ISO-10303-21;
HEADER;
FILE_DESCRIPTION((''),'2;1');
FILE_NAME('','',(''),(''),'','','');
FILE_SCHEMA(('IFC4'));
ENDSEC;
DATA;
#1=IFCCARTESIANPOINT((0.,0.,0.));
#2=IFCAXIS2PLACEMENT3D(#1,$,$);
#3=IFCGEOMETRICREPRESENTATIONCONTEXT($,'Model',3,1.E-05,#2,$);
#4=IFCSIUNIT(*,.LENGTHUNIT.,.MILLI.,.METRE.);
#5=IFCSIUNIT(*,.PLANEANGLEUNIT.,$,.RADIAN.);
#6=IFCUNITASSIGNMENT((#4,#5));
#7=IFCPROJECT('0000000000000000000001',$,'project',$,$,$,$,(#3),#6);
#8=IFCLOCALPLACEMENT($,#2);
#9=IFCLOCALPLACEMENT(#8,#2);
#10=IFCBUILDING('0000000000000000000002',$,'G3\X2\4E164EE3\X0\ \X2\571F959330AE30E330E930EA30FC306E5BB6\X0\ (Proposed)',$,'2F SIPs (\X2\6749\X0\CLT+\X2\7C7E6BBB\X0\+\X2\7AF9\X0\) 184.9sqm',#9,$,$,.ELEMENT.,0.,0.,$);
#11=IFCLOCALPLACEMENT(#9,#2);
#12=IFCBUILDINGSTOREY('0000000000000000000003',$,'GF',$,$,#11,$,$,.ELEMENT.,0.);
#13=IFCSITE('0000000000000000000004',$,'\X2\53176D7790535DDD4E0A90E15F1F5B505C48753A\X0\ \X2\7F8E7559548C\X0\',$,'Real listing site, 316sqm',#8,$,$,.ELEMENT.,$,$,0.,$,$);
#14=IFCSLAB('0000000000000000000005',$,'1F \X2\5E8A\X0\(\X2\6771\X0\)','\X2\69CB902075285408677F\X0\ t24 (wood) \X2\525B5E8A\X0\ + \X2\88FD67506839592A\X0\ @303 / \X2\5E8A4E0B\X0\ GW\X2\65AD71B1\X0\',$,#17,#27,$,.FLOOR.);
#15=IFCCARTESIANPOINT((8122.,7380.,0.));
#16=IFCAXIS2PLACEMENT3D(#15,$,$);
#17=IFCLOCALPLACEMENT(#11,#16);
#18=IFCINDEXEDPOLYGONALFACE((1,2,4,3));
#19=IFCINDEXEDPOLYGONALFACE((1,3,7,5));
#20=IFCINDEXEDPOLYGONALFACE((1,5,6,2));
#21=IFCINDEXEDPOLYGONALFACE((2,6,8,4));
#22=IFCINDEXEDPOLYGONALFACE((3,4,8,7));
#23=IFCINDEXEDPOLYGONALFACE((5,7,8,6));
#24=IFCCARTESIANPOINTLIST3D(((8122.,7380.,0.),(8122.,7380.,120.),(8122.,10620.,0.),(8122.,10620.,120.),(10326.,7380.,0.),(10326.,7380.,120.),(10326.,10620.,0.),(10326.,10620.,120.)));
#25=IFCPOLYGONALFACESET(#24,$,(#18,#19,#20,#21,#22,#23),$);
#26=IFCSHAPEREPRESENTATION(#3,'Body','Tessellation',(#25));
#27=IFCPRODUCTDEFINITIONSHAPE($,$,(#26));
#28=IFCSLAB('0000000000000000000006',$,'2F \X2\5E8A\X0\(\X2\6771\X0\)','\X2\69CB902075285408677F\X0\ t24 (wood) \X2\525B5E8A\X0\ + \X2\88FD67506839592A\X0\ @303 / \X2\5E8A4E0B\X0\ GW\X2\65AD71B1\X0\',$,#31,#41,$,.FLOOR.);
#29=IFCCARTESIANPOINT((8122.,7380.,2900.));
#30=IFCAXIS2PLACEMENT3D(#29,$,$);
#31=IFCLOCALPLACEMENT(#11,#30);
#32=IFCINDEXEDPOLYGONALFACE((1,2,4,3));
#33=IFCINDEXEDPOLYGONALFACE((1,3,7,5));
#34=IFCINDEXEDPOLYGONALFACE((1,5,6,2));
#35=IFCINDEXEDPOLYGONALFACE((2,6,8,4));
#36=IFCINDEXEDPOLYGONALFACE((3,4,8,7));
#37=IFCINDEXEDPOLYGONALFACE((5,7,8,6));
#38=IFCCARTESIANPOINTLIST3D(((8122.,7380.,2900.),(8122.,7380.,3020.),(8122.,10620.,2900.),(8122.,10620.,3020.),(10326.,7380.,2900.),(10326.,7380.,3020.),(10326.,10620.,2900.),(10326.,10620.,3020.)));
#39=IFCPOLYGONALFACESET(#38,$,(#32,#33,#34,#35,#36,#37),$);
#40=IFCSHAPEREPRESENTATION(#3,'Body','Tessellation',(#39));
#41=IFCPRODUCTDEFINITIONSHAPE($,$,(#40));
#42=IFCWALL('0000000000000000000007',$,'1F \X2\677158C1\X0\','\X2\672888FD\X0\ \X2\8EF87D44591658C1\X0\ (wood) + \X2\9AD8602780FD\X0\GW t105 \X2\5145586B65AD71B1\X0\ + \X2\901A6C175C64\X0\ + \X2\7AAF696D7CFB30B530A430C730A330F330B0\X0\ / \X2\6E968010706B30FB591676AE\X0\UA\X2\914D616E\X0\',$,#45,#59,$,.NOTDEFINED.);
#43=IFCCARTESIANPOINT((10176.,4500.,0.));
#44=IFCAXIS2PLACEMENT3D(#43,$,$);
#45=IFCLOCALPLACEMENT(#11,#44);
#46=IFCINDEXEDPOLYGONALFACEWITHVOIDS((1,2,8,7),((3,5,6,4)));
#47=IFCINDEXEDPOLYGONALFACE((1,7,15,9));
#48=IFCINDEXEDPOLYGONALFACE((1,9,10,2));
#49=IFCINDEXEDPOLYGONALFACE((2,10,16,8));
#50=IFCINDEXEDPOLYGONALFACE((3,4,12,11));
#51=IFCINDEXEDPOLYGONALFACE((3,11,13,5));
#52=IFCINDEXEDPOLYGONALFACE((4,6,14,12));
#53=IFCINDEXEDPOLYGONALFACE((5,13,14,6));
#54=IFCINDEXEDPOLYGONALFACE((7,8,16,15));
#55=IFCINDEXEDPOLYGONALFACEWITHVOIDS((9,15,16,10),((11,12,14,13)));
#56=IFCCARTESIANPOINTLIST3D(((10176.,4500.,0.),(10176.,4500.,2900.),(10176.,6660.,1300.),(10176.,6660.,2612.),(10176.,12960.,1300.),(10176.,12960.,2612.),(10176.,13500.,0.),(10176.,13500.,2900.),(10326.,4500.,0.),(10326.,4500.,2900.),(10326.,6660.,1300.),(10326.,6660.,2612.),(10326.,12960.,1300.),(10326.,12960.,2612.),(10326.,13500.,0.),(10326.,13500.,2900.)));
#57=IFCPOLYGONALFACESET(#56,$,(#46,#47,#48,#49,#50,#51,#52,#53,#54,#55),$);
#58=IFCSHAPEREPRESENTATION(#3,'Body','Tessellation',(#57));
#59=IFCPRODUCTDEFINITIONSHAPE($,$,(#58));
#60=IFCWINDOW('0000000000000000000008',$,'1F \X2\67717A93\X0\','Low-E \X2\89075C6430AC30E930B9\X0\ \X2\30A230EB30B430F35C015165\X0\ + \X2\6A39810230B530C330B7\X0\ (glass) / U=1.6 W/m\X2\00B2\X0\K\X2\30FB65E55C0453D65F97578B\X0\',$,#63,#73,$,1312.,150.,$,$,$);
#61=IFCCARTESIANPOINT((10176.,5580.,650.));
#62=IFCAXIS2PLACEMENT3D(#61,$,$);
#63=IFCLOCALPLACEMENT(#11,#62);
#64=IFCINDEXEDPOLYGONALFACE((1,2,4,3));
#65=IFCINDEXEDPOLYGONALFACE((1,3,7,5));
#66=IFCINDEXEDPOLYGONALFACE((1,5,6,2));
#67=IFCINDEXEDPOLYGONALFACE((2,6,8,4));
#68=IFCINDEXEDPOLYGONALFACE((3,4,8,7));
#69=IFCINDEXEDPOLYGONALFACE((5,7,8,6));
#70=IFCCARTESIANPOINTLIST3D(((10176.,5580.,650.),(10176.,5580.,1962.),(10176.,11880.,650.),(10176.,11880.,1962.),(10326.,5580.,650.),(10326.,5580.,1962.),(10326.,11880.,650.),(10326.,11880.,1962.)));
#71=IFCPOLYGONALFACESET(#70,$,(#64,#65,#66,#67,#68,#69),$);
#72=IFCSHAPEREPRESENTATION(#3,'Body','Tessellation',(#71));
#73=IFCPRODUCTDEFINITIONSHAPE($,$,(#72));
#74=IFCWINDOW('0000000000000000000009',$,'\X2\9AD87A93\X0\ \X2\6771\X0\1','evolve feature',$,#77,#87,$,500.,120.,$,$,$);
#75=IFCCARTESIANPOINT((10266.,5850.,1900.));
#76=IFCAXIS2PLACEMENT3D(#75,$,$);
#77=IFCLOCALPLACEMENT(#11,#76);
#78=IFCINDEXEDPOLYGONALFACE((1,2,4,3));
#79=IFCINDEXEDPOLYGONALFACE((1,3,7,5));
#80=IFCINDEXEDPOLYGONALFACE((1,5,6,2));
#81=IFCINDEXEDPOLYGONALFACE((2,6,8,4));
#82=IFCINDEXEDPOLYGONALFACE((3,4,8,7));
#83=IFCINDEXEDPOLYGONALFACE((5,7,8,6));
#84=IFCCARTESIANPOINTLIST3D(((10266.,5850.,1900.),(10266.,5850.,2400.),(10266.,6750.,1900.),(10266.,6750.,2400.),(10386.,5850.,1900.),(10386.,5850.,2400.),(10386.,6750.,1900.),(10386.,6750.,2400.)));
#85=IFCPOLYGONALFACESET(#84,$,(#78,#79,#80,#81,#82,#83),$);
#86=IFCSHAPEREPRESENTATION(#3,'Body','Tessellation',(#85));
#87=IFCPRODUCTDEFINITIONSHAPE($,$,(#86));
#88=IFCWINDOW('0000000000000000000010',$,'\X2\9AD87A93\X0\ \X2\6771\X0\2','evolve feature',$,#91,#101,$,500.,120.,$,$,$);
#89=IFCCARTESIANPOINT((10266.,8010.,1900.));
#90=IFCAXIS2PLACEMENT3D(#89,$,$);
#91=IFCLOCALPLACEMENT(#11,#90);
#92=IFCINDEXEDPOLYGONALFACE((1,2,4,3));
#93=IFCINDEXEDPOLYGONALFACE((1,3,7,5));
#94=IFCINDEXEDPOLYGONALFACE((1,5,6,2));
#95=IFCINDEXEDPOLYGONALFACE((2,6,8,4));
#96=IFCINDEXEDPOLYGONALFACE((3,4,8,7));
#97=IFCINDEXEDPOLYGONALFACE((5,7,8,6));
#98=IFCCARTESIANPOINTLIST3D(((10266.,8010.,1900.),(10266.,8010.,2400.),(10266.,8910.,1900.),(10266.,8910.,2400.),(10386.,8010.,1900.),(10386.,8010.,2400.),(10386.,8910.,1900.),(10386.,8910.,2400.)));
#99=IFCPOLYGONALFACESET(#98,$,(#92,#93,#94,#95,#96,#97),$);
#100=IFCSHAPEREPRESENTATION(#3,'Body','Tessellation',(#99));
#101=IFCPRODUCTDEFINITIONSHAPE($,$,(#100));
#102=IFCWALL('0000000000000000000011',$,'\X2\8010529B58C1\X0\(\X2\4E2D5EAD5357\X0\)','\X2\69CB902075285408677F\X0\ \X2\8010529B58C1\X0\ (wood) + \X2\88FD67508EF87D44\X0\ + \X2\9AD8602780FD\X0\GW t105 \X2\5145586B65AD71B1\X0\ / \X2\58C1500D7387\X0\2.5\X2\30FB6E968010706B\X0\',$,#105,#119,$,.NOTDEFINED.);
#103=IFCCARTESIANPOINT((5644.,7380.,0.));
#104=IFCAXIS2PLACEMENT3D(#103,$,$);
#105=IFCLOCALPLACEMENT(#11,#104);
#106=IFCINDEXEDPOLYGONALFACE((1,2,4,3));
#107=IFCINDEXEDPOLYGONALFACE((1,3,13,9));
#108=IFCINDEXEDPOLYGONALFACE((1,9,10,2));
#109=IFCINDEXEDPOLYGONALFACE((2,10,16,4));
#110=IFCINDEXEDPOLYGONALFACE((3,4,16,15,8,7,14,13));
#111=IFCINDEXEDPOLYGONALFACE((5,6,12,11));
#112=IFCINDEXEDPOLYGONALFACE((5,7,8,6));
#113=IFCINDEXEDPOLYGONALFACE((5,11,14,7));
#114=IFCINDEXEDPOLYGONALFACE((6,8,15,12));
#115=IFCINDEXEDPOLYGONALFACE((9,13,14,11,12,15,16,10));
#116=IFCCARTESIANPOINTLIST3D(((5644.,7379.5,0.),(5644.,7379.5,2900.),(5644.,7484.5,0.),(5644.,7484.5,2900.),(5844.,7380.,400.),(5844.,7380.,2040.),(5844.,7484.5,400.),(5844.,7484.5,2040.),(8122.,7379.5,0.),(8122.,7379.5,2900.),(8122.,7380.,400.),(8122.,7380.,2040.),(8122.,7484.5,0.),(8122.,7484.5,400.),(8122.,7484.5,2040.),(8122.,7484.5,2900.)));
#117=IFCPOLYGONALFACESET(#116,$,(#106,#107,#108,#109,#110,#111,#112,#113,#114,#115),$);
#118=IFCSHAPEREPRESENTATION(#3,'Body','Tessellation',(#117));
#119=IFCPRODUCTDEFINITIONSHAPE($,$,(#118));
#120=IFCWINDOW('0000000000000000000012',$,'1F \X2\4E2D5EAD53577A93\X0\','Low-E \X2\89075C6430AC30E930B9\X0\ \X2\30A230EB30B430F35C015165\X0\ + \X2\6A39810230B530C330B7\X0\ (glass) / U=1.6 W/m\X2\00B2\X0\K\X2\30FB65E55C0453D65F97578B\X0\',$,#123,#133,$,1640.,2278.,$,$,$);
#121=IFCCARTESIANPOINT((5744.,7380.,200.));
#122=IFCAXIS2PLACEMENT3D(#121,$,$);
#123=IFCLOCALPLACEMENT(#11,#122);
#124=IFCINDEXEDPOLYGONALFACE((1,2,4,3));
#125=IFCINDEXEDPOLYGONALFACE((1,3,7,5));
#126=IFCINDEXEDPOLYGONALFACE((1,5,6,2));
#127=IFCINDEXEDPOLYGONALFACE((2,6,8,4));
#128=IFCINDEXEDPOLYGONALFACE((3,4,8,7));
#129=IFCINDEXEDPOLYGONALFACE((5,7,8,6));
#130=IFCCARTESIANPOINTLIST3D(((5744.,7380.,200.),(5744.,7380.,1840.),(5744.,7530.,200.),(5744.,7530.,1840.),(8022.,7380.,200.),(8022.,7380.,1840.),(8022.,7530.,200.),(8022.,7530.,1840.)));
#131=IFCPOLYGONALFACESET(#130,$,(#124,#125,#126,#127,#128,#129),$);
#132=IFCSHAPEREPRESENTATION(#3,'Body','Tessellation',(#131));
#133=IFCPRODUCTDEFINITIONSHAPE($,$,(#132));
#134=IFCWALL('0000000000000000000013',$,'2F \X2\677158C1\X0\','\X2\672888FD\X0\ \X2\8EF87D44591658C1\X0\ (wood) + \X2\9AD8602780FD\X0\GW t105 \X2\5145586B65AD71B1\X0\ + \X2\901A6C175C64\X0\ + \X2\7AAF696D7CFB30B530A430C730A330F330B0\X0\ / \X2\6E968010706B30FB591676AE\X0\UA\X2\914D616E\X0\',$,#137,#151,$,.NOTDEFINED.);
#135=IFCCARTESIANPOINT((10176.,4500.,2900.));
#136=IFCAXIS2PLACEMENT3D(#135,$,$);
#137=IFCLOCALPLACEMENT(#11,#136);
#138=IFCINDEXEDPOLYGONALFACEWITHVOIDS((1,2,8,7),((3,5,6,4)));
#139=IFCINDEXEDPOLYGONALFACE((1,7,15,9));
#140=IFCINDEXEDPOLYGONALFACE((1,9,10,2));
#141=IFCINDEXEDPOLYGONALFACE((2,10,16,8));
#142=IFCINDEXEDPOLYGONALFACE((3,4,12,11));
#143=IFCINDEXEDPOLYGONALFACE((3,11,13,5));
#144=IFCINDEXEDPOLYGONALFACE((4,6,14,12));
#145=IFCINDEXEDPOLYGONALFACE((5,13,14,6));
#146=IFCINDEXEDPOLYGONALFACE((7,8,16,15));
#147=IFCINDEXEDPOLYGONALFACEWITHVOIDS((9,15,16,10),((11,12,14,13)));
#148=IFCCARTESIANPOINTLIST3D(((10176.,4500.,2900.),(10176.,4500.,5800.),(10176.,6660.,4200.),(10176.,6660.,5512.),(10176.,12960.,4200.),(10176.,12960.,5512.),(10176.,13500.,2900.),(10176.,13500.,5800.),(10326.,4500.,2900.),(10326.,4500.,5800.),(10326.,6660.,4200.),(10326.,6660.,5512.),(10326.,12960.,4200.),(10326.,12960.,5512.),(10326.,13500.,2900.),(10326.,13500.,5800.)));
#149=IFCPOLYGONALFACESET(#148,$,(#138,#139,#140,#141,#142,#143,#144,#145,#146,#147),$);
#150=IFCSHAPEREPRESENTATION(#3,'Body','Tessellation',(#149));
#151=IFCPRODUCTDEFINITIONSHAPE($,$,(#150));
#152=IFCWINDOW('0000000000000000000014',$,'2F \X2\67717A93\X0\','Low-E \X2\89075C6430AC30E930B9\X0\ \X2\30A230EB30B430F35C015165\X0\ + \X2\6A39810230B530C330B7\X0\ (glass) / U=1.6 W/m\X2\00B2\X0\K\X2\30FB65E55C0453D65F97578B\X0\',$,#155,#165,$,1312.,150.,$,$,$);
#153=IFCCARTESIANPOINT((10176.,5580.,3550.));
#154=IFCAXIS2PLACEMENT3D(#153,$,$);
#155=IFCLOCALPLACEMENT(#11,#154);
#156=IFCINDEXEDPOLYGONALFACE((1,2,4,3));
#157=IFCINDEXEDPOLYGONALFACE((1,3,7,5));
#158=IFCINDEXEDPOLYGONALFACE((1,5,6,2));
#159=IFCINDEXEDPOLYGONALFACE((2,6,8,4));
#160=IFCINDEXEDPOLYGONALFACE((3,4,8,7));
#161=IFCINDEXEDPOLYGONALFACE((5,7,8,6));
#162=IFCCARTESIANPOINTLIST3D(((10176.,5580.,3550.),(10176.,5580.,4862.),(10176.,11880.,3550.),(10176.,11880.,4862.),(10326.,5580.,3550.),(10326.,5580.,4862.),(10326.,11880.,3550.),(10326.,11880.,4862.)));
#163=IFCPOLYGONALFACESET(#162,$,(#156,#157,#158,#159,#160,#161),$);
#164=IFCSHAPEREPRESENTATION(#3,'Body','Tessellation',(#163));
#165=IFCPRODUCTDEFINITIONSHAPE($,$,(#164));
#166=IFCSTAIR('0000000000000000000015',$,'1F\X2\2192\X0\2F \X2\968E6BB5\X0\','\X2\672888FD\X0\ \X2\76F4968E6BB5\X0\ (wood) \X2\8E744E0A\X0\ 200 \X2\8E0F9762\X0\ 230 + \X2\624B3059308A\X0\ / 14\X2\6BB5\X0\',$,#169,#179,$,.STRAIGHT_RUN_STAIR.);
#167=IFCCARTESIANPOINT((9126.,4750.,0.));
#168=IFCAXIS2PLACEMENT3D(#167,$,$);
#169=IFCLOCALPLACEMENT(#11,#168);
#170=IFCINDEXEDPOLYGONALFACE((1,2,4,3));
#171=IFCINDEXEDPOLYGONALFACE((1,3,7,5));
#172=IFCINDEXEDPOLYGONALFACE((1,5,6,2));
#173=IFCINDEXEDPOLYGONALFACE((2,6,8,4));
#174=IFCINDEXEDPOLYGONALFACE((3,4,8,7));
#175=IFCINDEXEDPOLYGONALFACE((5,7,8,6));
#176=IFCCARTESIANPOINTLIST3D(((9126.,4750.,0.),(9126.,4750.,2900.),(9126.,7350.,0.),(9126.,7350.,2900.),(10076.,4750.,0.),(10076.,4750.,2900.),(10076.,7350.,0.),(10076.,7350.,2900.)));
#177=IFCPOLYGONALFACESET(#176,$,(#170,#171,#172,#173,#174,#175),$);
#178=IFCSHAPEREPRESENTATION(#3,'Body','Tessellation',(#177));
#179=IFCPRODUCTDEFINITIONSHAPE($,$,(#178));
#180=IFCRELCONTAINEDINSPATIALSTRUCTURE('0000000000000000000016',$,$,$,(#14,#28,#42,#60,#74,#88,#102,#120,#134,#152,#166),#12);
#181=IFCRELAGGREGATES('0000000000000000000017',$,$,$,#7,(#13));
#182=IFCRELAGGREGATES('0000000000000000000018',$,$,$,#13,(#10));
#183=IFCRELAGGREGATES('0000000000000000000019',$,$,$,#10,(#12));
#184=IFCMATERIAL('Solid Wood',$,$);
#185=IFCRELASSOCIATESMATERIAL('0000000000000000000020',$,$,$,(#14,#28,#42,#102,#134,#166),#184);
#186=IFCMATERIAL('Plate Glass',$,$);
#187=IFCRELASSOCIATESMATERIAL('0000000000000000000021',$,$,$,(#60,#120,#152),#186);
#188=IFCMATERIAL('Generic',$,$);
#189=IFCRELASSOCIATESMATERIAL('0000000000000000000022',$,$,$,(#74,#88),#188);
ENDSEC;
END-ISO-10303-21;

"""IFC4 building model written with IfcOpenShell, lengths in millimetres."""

from ifc_helpers import new_model, si_unit, frame, frame_2d, origin, place, context, project, spatial, rectangle, extrude, material, element, fill, save


model = new_model("IFC4")

# Units and contexts
model_context = context("Model", 3, precision=1e-05, world=origin())
ifc_project = project(units=[si_unit("LENGTHUNIT", "METRE", prefix="MILLI"), si_unit("PLANEANGLEUNIT", "RADIAN")], contexts=[model_context])

# Site, building, storey
site_placement = place(None, origin())
site = spatial("IfcSite", under=ifc_project, at=site_placement, Name="北海道川上郡弟子屈町 美留和", ObjectType="Real listing site, 316sqm", CompositionType="ELEMENT", RefElevation=0.0)
building_placement = place(site_placement, origin())
building = spatial("IfcBuilding", under=site, at=building_placement, Name="G3世代 土間ギャラリーの家 (Proposed)", ObjectType="2F SIPs (杉CLT+籾殻+竹) 184.9sqm", CompositionType="ELEMENT", ElevationOfRefHeight=0.0, ElevationOfTerrain=0.0)
storey_placement = place(building_placement, origin())
storey = spatial("IfcBuildingStorey", under=building, at=storey_placement, Name="GF", CompositionType="ELEMENT", Elevation=0.0)

# Slabs
ifc_material_1 = material(Name="Solid Wood")
slab_1_placement = place(storey_placement, frame((8122.0, 7380.0, 0.0)))
element("IfcSlab", 1, at=slab_1_placement, inside=storey, material=ifc_material_1, Name="1F 床(東)", Description="構造用合板 t24 (wood) 剛床 + 製材根太 @303 / 床下 GW断熱", PredefinedType="FLOOR", context=model_context, shape_type="SweptSolid", body=[
    extrude(rectangle(XDim=2204.0, YDim=3240.0, at=frame_2d((1102.0, 1620.0))), frame((8122.0, 7380.0, 0.0)), (0.0, 0.0, 1.0), 120.0),
])
slab_2_placement = place(storey_placement, frame((8122.0, 7380.0, 2900.0)))
element("IfcSlab", 2, at=slab_2_placement, inside=storey, material=ifc_material_1, Name="2F 床(東)", Description="構造用合板 t24 (wood) 剛床 + 製材根太 @303 / 床下 GW断熱", PredefinedType="FLOOR", context=model_context, shape_type="SweptSolid", body=[
    extrude(rectangle(XDim=2204.0, YDim=3240.0, at=frame_2d((1102.0, 1620.0))), frame((8122.0, 7380.0, 2900.0)), (0.0, 0.0, 1.0), 120.0),
])

# Wall, openings, windows
wall_1_placement = place(storey_placement, frame((10176.0, 4500.0, 0.0)))
wall_1 = element("IfcWall", 3, at=wall_1_placement, inside=storey, material=ifc_material_1, Name="1F 東壁", Description="木製 軸組外壁 (wood) + 高性能GW t105 充填断熱 + 通気層 + 窯業系サイディング / 準耐火・外皮UA配慮", PredefinedType="NOTDEFINED", context=model_context, shape_type="SweptSolid", body=[
    extrude(rectangle(XDim=150.0, YDim=9000.0, at=frame_2d((75.0, 4500.0))), frame((10176.0, 4500.0, 0.0)), (0.0, 0.0, 1.0), 2900.0),
])
opening_1_placement = place(storey_placement, frame((10176.0, 5580.0, 650.0)))
opening_1 = element("IfcOpeningElement", 4, at=opening_1_placement, cuts=wall_1, PredefinedType="NOTDEFINED", context=model_context, shape_type="SweptSolid", body=[
    extrude(rectangle(XDim=150.0, YDim=6300.0, at=frame_2d((75.0, 3150.0))), frame((10176.0, 5580.0, 650.0)), (0.0, 0.0, 1.0), 1312.0),
])
opening_2_placement = place(storey_placement, frame((10266.0, 5850.0, 1900.0)))
opening_2 = element("IfcOpeningElement", 5, at=opening_2_placement, cuts=wall_1, PredefinedType="NOTDEFINED", context=model_context, shape_type="SweptSolid", body=[
    extrude(rectangle(XDim=120.0, YDim=900.0, at=frame_2d((60.0, 450.0))), frame((10266.0, 5850.0, 1900.0)), (0.0, 0.0, 1.0), 500.0),
])
opening_3_placement = place(storey_placement, frame((10266.0, 8010.0, 1900.0)))
opening_3 = element("IfcOpeningElement", 6, at=opening_3_placement, cuts=wall_1, PredefinedType="NOTDEFINED", context=model_context, shape_type="SweptSolid", body=[
    extrude(rectangle(XDim=120.0, YDim=900.0, at=frame_2d((60.0, 450.0))), frame((10266.0, 8010.0, 1900.0)), (0.0, 0.0, 1.0), 500.0),
])
ifc_material_2 = material(Name="Plate Glass")
window_1_placement = place(storey_placement, frame((10176.0, 5580.0, 650.0)))
window_1 = element("IfcWindow", 7, at=window_1_placement, inside=storey, material=ifc_material_2, Name="1F 東窓", Description="Low-E 複層ガラス アルゴン封入 + 樹脂サッシ (glass) / U=1.6 W/m²K・日射取得型", OverallHeight=1312.0, OverallWidth=150.0, context=model_context, shape_type="SweptSolid", body=[
    extrude(rectangle(XDim=150.0, YDim=6300.0, at=frame_2d((75.0, 3150.0))), frame((10176.0, 5580.0, 650.0)), (0.0, 0.0, 1.0), 1312.0),
])
fill(opening_1, window_1)
ifc_material_3 = material(Name="Generic")
window_2_placement = place(storey_placement, frame((10266.0, 5850.0, 1900.0)))
window_2 = element("IfcWindow", 8, at=window_2_placement, inside=storey, material=ifc_material_3, Name="高窓 東1", Description="evolve feature", OverallHeight=500.0, OverallWidth=120.0, context=model_context, shape_type="SweptSolid", body=[
    extrude(rectangle(XDim=120.0, YDim=900.0, at=frame_2d((60.0, 450.0))), frame((10266.0, 5850.0, 1900.0)), (0.0, 0.0, 1.0), 500.0),
])
fill(opening_2, window_2)
window_3_placement = place(storey_placement, frame((10266.0, 8010.0, 1900.0)))
window_3 = element("IfcWindow", 9, at=window_3_placement, inside=storey, material=ifc_material_3, Name="高窓 東2", Description="evolve feature", OverallHeight=500.0, OverallWidth=120.0, context=model_context, shape_type="SweptSolid", body=[
    extrude(rectangle(XDim=120.0, YDim=900.0, at=frame_2d((60.0, 450.0))), frame((10266.0, 8010.0, 1900.0)), (0.0, 0.0, 1.0), 500.0),
])
fill(opening_3, window_3)

# Wall, opening, window
wall_2_placement = place(storey_placement, frame((5644.0, 7380.0, 0.0)))
wall_2 = element("IfcWall", 10, at=wall_2_placement, inside=storey, material=ifc_material_1, Name="耐力壁(中庭南)", Description="構造用合板 耐力壁 (wood) + 製材軸組 + 高性能GW t105 充填断熱 / 壁倍率2.5・準耐火", PredefinedType="NOTDEFINED", context=model_context, shape_type="SweptSolid", body=[
    extrude(rectangle(XDim=2478.0, YDim=105.0, at=frame_2d((1239.0, 52.0))), frame((5644.0, 7380.0, 0.0)), (0.0, 0.0, 1.0), 2900.0),
])
opening_4_placement = place(storey_placement, frame((5744.0, 7380.0, 200.0)))
opening_4 = element("IfcOpeningElement", 11, at=opening_4_placement, cuts=wall_2, PredefinedType="NOTDEFINED", context=model_context, shape_type="SweptSolid", body=[
    extrude(rectangle(XDim=2278.0, YDim=150.0, at=frame_2d((1139.0, 75.0))), frame((5744.0, 7380.0, 200.0)), (0.0, 0.0, 1.0), 1640.0),
])
window_4_placement = place(storey_placement, frame((5744.0, 7380.0, 200.0)))
window_4 = element("IfcWindow", 12, at=window_4_placement, inside=storey, material=ifc_material_2, Name="1F 中庭南窓", Description="Low-E 複層ガラス アルゴン封入 + 樹脂サッシ (glass) / U=1.6 W/m²K・日射取得型", OverallHeight=1640.0, OverallWidth=2278.0, context=model_context, shape_type="SweptSolid", body=[
    extrude(rectangle(XDim=2278.0, YDim=150.0, at=frame_2d((1139.0, 75.0))), frame((5744.0, 7380.0, 200.0)), (0.0, 0.0, 1.0), 1640.0),
])
fill(opening_4, window_4)

# Wall, opening, window
wall_3_placement = place(storey_placement, frame((10176.0, 4500.0, 2900.0)))
wall_3 = element("IfcWall", 13, at=wall_3_placement, inside=storey, material=ifc_material_1, Name="2F 東壁", Description="木製 軸組外壁 (wood) + 高性能GW t105 充填断熱 + 通気層 + 窯業系サイディング / 準耐火・外皮UA配慮", PredefinedType="NOTDEFINED", context=model_context, shape_type="SweptSolid", body=[
    extrude(rectangle(XDim=150.0, YDim=9000.0, at=frame_2d((75.0, 4500.0))), frame((10176.0, 4500.0, 2900.0)), (0.0, 0.0, 1.0), 2900.0),
])
opening_5_placement = place(storey_placement, frame((10176.0, 5580.0, 3550.0)))
opening_5 = element("IfcOpeningElement", 14, at=opening_5_placement, cuts=wall_3, PredefinedType="NOTDEFINED", context=model_context, shape_type="SweptSolid", body=[
    extrude(rectangle(XDim=150.0, YDim=6300.0, at=frame_2d((75.0, 3150.0))), frame((10176.0, 5580.0, 3550.0)), (0.0, 0.0, 1.0), 1312.0),
])
window_5_placement = place(storey_placement, frame((10176.0, 5580.0, 3550.0)))
window_5 = element("IfcWindow", 15, at=window_5_placement, inside=storey, material=ifc_material_2, Name="2F 東窓", Description="Low-E 複層ガラス アルゴン封入 + 樹脂サッシ (glass) / U=1.6 W/m²K・日射取得型", OverallHeight=1312.0, OverallWidth=150.0, context=model_context, shape_type="SweptSolid", body=[
    extrude(rectangle(XDim=150.0, YDim=6300.0, at=frame_2d((75.0, 3150.0))), frame((10176.0, 5580.0, 3550.0)), (0.0, 0.0, 1.0), 1312.0),
])
fill(opening_5, window_5)

# Stair
stair_placement = place(storey_placement, frame((9126.0, 4750.0, 0.0)))
element("IfcStair", 16, at=stair_placement, inside=storey, material=ifc_material_1, Name="1F→2F 階段", Description="木製 直階段 (wood) 蹴上 200 踏面 230 + 手すり / 14段", PredefinedType="STRAIGHT_RUN_STAIR", context=model_context, shape_type="SweptSolid", body=[
    extrude(rectangle(XDim=950.0, YDim=2600.0, at=frame_2d((475.0, 1300.0))), frame((9126.0, 4750.0, 0.0)), (0.0, 0.0, 1.0), 2900.0),
])

save(model, "model.ifc")
